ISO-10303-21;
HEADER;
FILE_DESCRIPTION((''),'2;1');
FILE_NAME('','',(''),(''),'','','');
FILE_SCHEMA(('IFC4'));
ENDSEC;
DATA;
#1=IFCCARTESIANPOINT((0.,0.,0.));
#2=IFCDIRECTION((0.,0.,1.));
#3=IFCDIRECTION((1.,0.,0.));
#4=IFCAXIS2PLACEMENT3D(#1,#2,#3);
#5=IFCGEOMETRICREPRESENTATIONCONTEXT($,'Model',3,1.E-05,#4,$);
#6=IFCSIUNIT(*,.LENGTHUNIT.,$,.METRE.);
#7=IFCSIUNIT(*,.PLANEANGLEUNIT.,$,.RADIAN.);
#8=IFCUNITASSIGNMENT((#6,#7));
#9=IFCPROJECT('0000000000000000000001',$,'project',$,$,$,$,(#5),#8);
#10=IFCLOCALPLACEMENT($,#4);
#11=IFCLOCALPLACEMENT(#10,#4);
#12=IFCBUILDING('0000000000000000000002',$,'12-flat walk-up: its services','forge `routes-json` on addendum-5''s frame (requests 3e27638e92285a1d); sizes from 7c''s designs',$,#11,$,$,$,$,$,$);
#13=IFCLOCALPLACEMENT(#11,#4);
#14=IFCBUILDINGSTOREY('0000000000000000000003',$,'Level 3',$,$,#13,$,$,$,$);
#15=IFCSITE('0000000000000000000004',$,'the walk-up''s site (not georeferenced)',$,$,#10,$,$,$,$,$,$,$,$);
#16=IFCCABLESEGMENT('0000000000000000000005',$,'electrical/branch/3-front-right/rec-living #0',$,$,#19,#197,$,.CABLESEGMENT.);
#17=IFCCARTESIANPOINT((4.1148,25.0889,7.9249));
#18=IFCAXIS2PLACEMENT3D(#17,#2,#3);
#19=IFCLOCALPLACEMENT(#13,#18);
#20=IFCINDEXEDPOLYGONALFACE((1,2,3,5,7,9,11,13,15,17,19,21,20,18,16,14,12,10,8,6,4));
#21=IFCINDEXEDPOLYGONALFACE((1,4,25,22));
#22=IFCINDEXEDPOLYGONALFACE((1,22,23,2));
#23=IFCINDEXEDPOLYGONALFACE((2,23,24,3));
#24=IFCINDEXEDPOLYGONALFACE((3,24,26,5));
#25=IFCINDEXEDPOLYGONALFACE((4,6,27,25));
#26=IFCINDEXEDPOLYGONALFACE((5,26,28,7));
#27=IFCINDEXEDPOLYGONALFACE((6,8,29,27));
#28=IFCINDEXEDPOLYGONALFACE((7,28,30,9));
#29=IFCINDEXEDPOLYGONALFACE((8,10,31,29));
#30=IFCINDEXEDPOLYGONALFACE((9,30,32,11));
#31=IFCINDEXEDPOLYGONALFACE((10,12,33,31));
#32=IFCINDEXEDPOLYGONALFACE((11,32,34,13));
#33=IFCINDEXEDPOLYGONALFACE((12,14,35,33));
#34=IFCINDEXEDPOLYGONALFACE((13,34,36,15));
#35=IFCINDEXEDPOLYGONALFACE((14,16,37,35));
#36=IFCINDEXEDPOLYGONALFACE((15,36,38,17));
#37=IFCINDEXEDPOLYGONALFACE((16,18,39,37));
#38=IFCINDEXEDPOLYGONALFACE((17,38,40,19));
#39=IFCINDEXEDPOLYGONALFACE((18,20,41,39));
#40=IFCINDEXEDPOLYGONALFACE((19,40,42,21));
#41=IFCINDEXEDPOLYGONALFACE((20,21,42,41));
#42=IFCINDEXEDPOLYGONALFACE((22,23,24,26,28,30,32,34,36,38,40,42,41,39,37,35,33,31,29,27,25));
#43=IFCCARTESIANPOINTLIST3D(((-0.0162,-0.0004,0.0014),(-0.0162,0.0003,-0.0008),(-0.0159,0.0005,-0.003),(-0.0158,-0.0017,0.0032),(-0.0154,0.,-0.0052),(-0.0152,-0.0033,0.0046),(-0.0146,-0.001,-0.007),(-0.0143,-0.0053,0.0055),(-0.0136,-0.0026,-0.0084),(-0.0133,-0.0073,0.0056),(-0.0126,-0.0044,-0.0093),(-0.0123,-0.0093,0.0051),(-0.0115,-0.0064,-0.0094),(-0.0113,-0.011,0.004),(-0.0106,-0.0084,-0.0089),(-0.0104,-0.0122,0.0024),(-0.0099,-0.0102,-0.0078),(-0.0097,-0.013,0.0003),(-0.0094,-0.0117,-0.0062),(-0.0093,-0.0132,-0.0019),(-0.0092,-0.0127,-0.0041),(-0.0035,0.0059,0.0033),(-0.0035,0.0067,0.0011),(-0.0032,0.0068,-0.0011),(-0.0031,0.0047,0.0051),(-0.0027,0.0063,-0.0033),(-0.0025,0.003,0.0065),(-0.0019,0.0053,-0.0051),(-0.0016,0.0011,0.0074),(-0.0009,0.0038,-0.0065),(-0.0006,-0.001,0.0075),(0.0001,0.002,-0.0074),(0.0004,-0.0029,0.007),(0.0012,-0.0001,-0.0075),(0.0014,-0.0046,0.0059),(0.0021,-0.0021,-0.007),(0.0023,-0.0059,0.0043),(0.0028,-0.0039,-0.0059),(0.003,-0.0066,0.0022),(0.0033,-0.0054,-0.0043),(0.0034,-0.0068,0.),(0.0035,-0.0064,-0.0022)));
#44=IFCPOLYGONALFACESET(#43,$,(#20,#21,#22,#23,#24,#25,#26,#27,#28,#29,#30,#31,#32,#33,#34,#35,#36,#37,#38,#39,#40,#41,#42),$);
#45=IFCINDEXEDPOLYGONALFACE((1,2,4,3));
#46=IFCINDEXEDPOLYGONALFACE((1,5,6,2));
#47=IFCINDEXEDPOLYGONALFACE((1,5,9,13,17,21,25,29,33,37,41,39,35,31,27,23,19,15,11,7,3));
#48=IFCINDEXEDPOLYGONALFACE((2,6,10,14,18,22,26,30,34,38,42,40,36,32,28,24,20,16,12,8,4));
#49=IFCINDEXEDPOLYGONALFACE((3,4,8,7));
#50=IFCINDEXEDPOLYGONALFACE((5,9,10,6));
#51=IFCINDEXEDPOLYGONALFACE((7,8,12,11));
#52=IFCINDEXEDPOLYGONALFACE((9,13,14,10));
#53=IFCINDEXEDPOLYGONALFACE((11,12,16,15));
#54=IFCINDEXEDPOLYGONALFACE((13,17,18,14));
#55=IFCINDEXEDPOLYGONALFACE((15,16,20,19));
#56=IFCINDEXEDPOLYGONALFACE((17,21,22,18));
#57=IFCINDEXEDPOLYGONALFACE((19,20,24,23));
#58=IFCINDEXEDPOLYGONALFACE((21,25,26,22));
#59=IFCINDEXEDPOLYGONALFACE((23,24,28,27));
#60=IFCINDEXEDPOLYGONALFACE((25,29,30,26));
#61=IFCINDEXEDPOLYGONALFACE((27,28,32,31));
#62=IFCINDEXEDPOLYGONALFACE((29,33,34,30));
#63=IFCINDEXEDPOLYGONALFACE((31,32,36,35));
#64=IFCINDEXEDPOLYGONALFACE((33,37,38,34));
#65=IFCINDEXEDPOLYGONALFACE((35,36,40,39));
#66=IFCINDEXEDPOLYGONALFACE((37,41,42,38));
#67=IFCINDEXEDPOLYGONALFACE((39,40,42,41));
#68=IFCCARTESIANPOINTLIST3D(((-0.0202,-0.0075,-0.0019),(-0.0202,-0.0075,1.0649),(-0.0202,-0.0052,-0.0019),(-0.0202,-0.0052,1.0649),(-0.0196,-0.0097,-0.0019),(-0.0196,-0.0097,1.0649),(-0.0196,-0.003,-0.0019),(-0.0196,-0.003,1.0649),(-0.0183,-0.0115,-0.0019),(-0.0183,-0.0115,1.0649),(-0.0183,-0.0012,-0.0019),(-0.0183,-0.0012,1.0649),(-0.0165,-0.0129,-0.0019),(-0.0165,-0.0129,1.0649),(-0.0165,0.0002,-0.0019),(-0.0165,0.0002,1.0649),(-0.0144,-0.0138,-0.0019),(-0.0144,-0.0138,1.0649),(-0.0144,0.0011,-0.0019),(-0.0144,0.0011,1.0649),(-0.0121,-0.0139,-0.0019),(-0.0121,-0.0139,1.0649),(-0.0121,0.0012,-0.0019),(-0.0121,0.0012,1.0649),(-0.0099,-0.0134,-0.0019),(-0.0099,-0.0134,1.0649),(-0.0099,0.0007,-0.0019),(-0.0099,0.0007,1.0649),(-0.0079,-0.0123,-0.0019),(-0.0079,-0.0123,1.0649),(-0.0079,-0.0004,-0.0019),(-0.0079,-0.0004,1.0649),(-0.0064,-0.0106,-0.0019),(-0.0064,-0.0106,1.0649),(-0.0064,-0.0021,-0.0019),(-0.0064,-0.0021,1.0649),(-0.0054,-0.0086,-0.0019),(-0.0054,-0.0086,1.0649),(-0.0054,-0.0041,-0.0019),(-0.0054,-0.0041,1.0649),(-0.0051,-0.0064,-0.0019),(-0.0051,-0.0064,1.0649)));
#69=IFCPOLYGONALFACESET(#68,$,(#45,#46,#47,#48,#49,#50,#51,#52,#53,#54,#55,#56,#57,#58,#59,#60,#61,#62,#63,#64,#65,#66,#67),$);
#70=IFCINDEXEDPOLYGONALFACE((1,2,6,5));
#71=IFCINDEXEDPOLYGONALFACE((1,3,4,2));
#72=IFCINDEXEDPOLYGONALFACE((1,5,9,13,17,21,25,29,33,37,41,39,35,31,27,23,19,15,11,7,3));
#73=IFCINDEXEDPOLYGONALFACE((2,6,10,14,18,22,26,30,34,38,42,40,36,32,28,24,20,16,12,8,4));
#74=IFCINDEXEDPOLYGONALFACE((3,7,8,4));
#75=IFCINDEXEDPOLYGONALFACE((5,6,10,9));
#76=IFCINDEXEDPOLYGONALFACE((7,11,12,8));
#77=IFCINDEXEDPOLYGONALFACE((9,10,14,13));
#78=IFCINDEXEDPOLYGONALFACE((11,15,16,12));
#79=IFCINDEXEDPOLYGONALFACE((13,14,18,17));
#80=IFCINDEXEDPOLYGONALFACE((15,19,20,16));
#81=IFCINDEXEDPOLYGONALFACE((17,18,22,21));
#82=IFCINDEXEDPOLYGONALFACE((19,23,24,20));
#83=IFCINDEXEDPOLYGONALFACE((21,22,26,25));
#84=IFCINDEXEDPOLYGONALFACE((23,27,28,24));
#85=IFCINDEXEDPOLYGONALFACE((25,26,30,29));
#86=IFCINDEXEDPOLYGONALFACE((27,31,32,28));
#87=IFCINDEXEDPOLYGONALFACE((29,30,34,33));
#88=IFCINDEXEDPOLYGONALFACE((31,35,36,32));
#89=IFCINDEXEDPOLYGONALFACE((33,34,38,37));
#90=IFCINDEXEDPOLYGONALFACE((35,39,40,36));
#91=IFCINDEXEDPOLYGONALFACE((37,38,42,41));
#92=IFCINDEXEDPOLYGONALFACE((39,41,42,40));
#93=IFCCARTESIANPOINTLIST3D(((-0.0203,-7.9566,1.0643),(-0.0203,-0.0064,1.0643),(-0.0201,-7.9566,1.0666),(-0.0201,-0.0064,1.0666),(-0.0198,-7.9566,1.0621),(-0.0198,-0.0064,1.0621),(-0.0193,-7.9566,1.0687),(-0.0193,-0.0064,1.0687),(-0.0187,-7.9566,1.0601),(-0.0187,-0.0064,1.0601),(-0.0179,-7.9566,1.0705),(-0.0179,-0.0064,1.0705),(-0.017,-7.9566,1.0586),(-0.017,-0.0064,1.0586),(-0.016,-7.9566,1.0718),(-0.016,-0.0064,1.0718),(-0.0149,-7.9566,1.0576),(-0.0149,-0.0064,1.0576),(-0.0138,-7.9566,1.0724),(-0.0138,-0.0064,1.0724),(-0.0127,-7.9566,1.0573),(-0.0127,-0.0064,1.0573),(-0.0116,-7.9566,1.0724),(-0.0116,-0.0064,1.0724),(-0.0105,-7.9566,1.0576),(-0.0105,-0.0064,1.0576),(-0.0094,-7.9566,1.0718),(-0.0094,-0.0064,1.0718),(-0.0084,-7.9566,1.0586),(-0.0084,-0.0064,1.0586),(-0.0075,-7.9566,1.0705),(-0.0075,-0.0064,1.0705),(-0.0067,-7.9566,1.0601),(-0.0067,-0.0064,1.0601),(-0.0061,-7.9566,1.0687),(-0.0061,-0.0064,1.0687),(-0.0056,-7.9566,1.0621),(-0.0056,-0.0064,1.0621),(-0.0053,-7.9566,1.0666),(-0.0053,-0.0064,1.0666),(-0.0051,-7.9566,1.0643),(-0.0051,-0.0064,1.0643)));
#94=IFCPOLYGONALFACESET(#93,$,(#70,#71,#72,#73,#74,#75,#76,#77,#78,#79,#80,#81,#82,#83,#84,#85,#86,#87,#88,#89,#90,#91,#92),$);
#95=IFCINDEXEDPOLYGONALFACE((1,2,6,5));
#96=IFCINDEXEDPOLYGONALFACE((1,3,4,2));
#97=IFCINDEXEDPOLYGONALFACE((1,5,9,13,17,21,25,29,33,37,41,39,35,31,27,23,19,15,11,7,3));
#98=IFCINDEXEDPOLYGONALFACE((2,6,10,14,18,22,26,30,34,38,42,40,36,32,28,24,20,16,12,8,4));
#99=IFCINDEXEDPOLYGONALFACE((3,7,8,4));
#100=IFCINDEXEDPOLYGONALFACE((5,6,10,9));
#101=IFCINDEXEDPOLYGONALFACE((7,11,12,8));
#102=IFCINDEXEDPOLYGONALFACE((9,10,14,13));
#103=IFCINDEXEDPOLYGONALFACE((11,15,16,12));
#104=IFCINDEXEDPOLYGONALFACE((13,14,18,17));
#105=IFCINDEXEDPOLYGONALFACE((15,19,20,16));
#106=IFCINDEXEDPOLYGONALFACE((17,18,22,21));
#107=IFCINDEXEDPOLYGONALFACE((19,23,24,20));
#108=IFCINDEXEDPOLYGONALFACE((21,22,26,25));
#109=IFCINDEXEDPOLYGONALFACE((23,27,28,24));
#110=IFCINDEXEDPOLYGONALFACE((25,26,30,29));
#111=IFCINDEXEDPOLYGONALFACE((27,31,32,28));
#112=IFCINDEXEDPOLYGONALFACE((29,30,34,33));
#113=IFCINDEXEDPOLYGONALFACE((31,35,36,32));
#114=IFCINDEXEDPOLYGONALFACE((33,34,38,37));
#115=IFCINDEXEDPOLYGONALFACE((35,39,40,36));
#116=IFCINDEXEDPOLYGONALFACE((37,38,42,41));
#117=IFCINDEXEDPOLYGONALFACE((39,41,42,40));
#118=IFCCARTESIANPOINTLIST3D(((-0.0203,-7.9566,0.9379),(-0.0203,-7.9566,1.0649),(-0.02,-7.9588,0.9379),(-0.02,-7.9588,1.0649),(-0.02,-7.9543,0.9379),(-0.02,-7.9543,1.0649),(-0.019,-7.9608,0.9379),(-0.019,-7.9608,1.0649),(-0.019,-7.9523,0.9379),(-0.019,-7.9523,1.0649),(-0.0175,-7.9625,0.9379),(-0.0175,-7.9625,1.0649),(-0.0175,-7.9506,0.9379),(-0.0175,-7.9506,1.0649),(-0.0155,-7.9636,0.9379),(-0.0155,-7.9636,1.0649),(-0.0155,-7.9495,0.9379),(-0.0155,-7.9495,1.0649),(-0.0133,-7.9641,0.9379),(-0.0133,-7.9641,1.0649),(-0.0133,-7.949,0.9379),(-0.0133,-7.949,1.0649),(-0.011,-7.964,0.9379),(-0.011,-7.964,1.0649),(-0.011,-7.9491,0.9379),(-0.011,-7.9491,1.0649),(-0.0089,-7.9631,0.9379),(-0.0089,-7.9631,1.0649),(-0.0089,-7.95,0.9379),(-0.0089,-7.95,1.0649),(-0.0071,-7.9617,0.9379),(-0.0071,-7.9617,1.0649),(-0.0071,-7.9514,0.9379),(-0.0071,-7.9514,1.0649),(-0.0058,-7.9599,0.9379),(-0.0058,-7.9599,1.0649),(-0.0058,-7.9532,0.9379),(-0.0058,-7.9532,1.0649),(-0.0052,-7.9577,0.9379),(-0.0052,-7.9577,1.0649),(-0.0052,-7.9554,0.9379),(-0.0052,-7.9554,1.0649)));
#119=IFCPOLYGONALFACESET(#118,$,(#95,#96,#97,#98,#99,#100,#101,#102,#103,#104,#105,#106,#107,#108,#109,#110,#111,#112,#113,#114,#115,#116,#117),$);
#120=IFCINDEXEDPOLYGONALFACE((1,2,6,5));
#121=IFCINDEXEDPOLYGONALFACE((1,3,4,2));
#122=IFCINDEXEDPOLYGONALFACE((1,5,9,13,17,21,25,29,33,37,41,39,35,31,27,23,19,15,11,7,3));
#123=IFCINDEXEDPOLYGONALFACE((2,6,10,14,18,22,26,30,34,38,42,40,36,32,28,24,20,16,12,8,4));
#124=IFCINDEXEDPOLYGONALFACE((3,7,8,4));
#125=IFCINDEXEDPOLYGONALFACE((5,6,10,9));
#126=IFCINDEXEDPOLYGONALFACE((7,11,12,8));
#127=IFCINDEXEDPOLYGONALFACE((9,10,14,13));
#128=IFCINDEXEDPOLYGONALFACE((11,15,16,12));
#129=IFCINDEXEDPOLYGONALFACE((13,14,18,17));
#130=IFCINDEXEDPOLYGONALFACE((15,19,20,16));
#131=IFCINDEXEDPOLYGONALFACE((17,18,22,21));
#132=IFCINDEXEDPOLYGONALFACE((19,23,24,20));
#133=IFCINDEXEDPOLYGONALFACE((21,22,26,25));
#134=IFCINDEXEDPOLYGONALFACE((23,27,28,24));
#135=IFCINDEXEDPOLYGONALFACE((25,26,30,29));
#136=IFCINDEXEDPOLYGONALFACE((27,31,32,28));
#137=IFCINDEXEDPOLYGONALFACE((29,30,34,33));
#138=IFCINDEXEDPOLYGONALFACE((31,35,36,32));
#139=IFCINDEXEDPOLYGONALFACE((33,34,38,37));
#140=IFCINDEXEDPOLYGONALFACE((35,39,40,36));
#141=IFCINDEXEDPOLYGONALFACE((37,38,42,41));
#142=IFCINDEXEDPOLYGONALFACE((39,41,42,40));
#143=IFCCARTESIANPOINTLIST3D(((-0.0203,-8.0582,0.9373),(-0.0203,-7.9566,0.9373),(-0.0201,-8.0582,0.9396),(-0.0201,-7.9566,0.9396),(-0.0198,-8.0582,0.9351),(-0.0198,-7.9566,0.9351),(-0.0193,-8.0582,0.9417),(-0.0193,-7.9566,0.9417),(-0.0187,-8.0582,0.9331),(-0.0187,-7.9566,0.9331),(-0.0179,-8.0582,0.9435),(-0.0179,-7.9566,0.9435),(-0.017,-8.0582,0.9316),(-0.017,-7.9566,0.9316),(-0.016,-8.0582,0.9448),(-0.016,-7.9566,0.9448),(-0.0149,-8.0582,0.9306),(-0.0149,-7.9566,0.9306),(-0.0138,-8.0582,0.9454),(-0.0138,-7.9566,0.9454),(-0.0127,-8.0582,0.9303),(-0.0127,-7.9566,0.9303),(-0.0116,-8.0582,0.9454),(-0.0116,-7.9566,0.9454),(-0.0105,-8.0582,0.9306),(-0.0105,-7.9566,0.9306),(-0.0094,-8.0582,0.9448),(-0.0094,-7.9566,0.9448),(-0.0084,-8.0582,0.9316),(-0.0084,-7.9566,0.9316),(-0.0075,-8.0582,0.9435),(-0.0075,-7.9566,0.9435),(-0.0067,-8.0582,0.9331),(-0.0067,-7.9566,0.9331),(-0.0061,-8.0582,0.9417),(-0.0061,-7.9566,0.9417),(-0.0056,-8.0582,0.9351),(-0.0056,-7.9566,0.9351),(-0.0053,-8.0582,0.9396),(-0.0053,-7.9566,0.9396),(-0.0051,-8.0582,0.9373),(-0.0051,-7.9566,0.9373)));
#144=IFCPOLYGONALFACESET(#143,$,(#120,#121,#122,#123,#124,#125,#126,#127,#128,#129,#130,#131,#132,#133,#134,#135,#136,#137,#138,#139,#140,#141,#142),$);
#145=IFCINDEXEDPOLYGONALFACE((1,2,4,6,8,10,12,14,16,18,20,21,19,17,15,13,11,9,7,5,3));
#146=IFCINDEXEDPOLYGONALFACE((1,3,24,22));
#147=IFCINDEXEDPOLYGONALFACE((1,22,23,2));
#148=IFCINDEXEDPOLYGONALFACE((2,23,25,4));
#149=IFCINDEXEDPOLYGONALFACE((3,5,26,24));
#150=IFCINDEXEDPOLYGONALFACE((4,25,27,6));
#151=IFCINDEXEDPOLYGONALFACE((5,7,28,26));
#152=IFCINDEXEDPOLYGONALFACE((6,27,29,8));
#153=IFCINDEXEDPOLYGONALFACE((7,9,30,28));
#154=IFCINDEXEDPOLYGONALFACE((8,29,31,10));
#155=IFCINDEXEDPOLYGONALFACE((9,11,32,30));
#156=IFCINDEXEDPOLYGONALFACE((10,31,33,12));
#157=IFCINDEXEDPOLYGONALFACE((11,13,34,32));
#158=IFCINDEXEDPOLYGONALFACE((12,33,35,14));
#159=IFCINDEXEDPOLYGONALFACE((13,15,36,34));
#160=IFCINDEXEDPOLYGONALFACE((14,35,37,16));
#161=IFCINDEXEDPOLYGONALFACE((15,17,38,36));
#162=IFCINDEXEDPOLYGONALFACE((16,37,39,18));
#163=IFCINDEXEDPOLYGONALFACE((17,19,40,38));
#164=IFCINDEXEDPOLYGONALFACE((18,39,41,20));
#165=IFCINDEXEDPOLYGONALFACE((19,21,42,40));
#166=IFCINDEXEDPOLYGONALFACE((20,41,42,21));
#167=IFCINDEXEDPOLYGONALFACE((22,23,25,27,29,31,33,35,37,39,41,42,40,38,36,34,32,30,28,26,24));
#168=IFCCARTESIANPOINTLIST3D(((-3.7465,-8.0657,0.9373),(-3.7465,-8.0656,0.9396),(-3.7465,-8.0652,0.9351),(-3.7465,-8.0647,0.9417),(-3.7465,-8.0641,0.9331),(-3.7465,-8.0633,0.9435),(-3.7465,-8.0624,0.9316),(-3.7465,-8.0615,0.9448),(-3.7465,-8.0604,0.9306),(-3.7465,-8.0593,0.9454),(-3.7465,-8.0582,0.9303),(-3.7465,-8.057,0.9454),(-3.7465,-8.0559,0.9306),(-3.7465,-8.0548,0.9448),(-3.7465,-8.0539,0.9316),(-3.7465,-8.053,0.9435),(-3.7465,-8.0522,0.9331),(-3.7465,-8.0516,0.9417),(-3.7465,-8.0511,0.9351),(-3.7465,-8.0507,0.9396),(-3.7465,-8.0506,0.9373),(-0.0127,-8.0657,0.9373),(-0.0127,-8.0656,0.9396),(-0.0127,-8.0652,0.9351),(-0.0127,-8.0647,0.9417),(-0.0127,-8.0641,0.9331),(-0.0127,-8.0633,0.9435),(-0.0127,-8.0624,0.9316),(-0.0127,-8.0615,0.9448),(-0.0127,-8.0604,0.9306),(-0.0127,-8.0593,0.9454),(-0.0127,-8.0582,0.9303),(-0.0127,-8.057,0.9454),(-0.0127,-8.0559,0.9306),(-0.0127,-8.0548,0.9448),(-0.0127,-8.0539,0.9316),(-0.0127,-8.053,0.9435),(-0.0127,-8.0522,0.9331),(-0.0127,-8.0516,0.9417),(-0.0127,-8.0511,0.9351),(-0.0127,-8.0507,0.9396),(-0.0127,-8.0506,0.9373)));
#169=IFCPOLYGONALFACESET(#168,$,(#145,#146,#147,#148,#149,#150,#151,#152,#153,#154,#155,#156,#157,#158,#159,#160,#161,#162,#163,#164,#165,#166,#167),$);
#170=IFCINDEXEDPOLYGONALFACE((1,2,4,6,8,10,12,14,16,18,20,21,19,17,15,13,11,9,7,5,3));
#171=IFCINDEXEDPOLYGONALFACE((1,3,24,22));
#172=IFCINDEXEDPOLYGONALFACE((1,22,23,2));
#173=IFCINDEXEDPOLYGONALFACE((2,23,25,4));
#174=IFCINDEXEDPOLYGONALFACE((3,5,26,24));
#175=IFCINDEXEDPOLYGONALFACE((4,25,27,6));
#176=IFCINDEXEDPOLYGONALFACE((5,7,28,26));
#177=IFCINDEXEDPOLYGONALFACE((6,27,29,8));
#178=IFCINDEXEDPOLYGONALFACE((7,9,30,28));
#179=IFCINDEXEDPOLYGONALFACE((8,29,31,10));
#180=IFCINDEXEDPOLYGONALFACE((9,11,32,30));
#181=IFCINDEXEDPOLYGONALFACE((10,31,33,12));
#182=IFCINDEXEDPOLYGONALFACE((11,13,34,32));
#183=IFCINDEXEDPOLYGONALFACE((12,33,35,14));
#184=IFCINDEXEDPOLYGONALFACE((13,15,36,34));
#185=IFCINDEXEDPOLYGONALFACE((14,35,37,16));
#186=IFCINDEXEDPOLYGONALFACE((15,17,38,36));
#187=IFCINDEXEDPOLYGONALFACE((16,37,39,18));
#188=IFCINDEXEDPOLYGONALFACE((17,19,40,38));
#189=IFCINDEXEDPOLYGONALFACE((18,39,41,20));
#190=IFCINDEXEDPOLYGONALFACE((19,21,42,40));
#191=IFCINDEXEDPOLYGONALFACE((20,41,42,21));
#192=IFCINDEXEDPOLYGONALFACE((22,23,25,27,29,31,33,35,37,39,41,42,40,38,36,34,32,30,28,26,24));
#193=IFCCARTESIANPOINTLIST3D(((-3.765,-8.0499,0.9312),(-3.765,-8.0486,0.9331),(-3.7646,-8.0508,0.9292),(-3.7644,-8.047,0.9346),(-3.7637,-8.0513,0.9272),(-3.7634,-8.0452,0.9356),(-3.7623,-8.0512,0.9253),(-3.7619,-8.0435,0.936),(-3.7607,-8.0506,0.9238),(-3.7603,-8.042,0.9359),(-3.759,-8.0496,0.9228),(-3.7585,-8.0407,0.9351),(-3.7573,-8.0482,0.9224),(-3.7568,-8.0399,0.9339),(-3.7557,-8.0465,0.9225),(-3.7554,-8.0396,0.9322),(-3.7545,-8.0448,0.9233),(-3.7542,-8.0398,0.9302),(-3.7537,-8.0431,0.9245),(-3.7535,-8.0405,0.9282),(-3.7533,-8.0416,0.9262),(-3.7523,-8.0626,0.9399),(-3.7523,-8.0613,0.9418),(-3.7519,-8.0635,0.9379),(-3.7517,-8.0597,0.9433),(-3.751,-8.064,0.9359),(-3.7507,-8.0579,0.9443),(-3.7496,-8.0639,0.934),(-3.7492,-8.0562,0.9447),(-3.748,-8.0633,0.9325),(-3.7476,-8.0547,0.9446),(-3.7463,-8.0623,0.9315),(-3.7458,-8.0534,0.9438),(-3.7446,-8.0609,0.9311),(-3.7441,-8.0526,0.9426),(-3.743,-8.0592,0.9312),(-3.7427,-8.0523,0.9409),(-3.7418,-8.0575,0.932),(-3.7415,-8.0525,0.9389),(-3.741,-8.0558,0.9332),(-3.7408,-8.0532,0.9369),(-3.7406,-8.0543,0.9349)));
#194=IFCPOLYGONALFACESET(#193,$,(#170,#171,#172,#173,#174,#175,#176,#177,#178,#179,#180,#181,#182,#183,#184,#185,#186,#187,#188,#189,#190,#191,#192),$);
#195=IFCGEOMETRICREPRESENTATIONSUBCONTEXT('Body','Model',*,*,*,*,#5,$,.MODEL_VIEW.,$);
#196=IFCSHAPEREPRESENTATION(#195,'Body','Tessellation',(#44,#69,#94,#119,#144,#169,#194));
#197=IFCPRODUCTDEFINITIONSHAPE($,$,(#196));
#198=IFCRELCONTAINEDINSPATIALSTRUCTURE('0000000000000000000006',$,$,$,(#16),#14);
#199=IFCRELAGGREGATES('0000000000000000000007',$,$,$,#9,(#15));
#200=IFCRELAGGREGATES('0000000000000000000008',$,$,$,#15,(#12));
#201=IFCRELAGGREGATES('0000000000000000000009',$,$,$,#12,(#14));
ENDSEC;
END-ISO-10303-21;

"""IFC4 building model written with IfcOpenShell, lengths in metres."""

from ifc_helpers import new_model, entity, si_unit, frame, origin_with_axes, place, context, subcontext, project, spatial, element, save


model = new_model("IFC4")

# Units and contexts
model_context = context("Model", 3, precision=1e-05, world=origin_with_axes())
body_context = subcontext(model_context, "Body", "Model", "MODEL_VIEW")
ifc_project = project(units=[si_unit("LENGTHUNIT", "METRE"), si_unit("PLANEANGLEUNIT", "RADIAN")], contexts=[model_context])

# Site, building, storey
site_placement = place(None, origin_with_axes())
site = spatial("IfcSite", under=ifc_project, at=site_placement, Name="the walk-up's site (not georeferenced)")
building_placement = place(site_placement, origin_with_axes())
building = spatial("IfcBuilding", under=site, at=building_placement, Name="12-flat walk-up: its services", Description="forge `routes-json` on addendum-5's frame (requests 3e27638e92285a1d); sizes from 7c's designs")
storey_placement = place(building_placement, origin_with_axes())
storey = spatial("IfcBuildingStorey", under=building, at=storey_placement, Name="Level 3")

# Cable segment
cable_segment_1_placement = place(storey_placement, frame((4.1148, 25.0889, 7.9249), z_axis=(0.0, 0.0, 1.0), x_axis=(1.0, 0.0, 0.0)))
element("IfcCableSegment", 1, at=cable_segment_1_placement, inside=storey, Name="electrical/branch/3-front-right/rec-living #0", PredefinedType="CABLESEGMENT", context=body_context, shape_type="AdvancedSweptSolid", body=[
    entity("IfcSweptDiskSolid", entity("IfcPolyline", [entity("IfcCartesianPoint", [0.0, 0.0, 0.0]), entity("IfcCartesianPoint", [-0.0127, -0.0064, -0.0019])]), 0.0076),
    entity("IfcSweptDiskSolid", entity("IfcPolyline", [entity("IfcCartesianPoint", [-0.0127, -0.0064, -0.0019]), entity("IfcCartesianPoint", [-0.0127, -0.0064, 1.0649])]), 0.0076),
    entity("IfcSweptDiskSolid", entity("IfcPolyline", [entity("IfcCartesianPoint", [-0.0127, -0.0064, 1.0649]), entity("IfcCartesianPoint", [-0.0127, -7.9566, 1.0649])]), 0.0076),
    entity("IfcSweptDiskSolid", entity("IfcPolyline", [entity("IfcCartesianPoint", [-0.0127, -7.9566, 1.0649]), entity("IfcCartesianPoint", [-0.0127, -7.9566, 0.9379])]), 0.0076),
    entity("IfcSweptDiskSolid", entity("IfcPolyline", [entity("IfcCartesianPoint", [-0.0127, -7.9566, 0.9379]), entity("IfcCartesianPoint", [-0.0127, -8.0582, 0.9379])]), 0.0076),
    entity("IfcSweptDiskSolid", entity("IfcPolyline", [entity("IfcCartesianPoint", [-0.0127, -8.0582, 0.9379]), entity("IfcCartesianPoint", [-3.7465, -8.0582, 0.9379])]), 0.0076),
    entity("IfcSweptDiskSolid", entity("IfcPolyline", [entity("IfcCartesianPoint", [-3.7465, -8.0582, 0.9379]), entity("IfcCartesianPoint", [-3.7592, -8.0455, 0.9292])]), 0.0076),
])

save(model, "model.ifc")
